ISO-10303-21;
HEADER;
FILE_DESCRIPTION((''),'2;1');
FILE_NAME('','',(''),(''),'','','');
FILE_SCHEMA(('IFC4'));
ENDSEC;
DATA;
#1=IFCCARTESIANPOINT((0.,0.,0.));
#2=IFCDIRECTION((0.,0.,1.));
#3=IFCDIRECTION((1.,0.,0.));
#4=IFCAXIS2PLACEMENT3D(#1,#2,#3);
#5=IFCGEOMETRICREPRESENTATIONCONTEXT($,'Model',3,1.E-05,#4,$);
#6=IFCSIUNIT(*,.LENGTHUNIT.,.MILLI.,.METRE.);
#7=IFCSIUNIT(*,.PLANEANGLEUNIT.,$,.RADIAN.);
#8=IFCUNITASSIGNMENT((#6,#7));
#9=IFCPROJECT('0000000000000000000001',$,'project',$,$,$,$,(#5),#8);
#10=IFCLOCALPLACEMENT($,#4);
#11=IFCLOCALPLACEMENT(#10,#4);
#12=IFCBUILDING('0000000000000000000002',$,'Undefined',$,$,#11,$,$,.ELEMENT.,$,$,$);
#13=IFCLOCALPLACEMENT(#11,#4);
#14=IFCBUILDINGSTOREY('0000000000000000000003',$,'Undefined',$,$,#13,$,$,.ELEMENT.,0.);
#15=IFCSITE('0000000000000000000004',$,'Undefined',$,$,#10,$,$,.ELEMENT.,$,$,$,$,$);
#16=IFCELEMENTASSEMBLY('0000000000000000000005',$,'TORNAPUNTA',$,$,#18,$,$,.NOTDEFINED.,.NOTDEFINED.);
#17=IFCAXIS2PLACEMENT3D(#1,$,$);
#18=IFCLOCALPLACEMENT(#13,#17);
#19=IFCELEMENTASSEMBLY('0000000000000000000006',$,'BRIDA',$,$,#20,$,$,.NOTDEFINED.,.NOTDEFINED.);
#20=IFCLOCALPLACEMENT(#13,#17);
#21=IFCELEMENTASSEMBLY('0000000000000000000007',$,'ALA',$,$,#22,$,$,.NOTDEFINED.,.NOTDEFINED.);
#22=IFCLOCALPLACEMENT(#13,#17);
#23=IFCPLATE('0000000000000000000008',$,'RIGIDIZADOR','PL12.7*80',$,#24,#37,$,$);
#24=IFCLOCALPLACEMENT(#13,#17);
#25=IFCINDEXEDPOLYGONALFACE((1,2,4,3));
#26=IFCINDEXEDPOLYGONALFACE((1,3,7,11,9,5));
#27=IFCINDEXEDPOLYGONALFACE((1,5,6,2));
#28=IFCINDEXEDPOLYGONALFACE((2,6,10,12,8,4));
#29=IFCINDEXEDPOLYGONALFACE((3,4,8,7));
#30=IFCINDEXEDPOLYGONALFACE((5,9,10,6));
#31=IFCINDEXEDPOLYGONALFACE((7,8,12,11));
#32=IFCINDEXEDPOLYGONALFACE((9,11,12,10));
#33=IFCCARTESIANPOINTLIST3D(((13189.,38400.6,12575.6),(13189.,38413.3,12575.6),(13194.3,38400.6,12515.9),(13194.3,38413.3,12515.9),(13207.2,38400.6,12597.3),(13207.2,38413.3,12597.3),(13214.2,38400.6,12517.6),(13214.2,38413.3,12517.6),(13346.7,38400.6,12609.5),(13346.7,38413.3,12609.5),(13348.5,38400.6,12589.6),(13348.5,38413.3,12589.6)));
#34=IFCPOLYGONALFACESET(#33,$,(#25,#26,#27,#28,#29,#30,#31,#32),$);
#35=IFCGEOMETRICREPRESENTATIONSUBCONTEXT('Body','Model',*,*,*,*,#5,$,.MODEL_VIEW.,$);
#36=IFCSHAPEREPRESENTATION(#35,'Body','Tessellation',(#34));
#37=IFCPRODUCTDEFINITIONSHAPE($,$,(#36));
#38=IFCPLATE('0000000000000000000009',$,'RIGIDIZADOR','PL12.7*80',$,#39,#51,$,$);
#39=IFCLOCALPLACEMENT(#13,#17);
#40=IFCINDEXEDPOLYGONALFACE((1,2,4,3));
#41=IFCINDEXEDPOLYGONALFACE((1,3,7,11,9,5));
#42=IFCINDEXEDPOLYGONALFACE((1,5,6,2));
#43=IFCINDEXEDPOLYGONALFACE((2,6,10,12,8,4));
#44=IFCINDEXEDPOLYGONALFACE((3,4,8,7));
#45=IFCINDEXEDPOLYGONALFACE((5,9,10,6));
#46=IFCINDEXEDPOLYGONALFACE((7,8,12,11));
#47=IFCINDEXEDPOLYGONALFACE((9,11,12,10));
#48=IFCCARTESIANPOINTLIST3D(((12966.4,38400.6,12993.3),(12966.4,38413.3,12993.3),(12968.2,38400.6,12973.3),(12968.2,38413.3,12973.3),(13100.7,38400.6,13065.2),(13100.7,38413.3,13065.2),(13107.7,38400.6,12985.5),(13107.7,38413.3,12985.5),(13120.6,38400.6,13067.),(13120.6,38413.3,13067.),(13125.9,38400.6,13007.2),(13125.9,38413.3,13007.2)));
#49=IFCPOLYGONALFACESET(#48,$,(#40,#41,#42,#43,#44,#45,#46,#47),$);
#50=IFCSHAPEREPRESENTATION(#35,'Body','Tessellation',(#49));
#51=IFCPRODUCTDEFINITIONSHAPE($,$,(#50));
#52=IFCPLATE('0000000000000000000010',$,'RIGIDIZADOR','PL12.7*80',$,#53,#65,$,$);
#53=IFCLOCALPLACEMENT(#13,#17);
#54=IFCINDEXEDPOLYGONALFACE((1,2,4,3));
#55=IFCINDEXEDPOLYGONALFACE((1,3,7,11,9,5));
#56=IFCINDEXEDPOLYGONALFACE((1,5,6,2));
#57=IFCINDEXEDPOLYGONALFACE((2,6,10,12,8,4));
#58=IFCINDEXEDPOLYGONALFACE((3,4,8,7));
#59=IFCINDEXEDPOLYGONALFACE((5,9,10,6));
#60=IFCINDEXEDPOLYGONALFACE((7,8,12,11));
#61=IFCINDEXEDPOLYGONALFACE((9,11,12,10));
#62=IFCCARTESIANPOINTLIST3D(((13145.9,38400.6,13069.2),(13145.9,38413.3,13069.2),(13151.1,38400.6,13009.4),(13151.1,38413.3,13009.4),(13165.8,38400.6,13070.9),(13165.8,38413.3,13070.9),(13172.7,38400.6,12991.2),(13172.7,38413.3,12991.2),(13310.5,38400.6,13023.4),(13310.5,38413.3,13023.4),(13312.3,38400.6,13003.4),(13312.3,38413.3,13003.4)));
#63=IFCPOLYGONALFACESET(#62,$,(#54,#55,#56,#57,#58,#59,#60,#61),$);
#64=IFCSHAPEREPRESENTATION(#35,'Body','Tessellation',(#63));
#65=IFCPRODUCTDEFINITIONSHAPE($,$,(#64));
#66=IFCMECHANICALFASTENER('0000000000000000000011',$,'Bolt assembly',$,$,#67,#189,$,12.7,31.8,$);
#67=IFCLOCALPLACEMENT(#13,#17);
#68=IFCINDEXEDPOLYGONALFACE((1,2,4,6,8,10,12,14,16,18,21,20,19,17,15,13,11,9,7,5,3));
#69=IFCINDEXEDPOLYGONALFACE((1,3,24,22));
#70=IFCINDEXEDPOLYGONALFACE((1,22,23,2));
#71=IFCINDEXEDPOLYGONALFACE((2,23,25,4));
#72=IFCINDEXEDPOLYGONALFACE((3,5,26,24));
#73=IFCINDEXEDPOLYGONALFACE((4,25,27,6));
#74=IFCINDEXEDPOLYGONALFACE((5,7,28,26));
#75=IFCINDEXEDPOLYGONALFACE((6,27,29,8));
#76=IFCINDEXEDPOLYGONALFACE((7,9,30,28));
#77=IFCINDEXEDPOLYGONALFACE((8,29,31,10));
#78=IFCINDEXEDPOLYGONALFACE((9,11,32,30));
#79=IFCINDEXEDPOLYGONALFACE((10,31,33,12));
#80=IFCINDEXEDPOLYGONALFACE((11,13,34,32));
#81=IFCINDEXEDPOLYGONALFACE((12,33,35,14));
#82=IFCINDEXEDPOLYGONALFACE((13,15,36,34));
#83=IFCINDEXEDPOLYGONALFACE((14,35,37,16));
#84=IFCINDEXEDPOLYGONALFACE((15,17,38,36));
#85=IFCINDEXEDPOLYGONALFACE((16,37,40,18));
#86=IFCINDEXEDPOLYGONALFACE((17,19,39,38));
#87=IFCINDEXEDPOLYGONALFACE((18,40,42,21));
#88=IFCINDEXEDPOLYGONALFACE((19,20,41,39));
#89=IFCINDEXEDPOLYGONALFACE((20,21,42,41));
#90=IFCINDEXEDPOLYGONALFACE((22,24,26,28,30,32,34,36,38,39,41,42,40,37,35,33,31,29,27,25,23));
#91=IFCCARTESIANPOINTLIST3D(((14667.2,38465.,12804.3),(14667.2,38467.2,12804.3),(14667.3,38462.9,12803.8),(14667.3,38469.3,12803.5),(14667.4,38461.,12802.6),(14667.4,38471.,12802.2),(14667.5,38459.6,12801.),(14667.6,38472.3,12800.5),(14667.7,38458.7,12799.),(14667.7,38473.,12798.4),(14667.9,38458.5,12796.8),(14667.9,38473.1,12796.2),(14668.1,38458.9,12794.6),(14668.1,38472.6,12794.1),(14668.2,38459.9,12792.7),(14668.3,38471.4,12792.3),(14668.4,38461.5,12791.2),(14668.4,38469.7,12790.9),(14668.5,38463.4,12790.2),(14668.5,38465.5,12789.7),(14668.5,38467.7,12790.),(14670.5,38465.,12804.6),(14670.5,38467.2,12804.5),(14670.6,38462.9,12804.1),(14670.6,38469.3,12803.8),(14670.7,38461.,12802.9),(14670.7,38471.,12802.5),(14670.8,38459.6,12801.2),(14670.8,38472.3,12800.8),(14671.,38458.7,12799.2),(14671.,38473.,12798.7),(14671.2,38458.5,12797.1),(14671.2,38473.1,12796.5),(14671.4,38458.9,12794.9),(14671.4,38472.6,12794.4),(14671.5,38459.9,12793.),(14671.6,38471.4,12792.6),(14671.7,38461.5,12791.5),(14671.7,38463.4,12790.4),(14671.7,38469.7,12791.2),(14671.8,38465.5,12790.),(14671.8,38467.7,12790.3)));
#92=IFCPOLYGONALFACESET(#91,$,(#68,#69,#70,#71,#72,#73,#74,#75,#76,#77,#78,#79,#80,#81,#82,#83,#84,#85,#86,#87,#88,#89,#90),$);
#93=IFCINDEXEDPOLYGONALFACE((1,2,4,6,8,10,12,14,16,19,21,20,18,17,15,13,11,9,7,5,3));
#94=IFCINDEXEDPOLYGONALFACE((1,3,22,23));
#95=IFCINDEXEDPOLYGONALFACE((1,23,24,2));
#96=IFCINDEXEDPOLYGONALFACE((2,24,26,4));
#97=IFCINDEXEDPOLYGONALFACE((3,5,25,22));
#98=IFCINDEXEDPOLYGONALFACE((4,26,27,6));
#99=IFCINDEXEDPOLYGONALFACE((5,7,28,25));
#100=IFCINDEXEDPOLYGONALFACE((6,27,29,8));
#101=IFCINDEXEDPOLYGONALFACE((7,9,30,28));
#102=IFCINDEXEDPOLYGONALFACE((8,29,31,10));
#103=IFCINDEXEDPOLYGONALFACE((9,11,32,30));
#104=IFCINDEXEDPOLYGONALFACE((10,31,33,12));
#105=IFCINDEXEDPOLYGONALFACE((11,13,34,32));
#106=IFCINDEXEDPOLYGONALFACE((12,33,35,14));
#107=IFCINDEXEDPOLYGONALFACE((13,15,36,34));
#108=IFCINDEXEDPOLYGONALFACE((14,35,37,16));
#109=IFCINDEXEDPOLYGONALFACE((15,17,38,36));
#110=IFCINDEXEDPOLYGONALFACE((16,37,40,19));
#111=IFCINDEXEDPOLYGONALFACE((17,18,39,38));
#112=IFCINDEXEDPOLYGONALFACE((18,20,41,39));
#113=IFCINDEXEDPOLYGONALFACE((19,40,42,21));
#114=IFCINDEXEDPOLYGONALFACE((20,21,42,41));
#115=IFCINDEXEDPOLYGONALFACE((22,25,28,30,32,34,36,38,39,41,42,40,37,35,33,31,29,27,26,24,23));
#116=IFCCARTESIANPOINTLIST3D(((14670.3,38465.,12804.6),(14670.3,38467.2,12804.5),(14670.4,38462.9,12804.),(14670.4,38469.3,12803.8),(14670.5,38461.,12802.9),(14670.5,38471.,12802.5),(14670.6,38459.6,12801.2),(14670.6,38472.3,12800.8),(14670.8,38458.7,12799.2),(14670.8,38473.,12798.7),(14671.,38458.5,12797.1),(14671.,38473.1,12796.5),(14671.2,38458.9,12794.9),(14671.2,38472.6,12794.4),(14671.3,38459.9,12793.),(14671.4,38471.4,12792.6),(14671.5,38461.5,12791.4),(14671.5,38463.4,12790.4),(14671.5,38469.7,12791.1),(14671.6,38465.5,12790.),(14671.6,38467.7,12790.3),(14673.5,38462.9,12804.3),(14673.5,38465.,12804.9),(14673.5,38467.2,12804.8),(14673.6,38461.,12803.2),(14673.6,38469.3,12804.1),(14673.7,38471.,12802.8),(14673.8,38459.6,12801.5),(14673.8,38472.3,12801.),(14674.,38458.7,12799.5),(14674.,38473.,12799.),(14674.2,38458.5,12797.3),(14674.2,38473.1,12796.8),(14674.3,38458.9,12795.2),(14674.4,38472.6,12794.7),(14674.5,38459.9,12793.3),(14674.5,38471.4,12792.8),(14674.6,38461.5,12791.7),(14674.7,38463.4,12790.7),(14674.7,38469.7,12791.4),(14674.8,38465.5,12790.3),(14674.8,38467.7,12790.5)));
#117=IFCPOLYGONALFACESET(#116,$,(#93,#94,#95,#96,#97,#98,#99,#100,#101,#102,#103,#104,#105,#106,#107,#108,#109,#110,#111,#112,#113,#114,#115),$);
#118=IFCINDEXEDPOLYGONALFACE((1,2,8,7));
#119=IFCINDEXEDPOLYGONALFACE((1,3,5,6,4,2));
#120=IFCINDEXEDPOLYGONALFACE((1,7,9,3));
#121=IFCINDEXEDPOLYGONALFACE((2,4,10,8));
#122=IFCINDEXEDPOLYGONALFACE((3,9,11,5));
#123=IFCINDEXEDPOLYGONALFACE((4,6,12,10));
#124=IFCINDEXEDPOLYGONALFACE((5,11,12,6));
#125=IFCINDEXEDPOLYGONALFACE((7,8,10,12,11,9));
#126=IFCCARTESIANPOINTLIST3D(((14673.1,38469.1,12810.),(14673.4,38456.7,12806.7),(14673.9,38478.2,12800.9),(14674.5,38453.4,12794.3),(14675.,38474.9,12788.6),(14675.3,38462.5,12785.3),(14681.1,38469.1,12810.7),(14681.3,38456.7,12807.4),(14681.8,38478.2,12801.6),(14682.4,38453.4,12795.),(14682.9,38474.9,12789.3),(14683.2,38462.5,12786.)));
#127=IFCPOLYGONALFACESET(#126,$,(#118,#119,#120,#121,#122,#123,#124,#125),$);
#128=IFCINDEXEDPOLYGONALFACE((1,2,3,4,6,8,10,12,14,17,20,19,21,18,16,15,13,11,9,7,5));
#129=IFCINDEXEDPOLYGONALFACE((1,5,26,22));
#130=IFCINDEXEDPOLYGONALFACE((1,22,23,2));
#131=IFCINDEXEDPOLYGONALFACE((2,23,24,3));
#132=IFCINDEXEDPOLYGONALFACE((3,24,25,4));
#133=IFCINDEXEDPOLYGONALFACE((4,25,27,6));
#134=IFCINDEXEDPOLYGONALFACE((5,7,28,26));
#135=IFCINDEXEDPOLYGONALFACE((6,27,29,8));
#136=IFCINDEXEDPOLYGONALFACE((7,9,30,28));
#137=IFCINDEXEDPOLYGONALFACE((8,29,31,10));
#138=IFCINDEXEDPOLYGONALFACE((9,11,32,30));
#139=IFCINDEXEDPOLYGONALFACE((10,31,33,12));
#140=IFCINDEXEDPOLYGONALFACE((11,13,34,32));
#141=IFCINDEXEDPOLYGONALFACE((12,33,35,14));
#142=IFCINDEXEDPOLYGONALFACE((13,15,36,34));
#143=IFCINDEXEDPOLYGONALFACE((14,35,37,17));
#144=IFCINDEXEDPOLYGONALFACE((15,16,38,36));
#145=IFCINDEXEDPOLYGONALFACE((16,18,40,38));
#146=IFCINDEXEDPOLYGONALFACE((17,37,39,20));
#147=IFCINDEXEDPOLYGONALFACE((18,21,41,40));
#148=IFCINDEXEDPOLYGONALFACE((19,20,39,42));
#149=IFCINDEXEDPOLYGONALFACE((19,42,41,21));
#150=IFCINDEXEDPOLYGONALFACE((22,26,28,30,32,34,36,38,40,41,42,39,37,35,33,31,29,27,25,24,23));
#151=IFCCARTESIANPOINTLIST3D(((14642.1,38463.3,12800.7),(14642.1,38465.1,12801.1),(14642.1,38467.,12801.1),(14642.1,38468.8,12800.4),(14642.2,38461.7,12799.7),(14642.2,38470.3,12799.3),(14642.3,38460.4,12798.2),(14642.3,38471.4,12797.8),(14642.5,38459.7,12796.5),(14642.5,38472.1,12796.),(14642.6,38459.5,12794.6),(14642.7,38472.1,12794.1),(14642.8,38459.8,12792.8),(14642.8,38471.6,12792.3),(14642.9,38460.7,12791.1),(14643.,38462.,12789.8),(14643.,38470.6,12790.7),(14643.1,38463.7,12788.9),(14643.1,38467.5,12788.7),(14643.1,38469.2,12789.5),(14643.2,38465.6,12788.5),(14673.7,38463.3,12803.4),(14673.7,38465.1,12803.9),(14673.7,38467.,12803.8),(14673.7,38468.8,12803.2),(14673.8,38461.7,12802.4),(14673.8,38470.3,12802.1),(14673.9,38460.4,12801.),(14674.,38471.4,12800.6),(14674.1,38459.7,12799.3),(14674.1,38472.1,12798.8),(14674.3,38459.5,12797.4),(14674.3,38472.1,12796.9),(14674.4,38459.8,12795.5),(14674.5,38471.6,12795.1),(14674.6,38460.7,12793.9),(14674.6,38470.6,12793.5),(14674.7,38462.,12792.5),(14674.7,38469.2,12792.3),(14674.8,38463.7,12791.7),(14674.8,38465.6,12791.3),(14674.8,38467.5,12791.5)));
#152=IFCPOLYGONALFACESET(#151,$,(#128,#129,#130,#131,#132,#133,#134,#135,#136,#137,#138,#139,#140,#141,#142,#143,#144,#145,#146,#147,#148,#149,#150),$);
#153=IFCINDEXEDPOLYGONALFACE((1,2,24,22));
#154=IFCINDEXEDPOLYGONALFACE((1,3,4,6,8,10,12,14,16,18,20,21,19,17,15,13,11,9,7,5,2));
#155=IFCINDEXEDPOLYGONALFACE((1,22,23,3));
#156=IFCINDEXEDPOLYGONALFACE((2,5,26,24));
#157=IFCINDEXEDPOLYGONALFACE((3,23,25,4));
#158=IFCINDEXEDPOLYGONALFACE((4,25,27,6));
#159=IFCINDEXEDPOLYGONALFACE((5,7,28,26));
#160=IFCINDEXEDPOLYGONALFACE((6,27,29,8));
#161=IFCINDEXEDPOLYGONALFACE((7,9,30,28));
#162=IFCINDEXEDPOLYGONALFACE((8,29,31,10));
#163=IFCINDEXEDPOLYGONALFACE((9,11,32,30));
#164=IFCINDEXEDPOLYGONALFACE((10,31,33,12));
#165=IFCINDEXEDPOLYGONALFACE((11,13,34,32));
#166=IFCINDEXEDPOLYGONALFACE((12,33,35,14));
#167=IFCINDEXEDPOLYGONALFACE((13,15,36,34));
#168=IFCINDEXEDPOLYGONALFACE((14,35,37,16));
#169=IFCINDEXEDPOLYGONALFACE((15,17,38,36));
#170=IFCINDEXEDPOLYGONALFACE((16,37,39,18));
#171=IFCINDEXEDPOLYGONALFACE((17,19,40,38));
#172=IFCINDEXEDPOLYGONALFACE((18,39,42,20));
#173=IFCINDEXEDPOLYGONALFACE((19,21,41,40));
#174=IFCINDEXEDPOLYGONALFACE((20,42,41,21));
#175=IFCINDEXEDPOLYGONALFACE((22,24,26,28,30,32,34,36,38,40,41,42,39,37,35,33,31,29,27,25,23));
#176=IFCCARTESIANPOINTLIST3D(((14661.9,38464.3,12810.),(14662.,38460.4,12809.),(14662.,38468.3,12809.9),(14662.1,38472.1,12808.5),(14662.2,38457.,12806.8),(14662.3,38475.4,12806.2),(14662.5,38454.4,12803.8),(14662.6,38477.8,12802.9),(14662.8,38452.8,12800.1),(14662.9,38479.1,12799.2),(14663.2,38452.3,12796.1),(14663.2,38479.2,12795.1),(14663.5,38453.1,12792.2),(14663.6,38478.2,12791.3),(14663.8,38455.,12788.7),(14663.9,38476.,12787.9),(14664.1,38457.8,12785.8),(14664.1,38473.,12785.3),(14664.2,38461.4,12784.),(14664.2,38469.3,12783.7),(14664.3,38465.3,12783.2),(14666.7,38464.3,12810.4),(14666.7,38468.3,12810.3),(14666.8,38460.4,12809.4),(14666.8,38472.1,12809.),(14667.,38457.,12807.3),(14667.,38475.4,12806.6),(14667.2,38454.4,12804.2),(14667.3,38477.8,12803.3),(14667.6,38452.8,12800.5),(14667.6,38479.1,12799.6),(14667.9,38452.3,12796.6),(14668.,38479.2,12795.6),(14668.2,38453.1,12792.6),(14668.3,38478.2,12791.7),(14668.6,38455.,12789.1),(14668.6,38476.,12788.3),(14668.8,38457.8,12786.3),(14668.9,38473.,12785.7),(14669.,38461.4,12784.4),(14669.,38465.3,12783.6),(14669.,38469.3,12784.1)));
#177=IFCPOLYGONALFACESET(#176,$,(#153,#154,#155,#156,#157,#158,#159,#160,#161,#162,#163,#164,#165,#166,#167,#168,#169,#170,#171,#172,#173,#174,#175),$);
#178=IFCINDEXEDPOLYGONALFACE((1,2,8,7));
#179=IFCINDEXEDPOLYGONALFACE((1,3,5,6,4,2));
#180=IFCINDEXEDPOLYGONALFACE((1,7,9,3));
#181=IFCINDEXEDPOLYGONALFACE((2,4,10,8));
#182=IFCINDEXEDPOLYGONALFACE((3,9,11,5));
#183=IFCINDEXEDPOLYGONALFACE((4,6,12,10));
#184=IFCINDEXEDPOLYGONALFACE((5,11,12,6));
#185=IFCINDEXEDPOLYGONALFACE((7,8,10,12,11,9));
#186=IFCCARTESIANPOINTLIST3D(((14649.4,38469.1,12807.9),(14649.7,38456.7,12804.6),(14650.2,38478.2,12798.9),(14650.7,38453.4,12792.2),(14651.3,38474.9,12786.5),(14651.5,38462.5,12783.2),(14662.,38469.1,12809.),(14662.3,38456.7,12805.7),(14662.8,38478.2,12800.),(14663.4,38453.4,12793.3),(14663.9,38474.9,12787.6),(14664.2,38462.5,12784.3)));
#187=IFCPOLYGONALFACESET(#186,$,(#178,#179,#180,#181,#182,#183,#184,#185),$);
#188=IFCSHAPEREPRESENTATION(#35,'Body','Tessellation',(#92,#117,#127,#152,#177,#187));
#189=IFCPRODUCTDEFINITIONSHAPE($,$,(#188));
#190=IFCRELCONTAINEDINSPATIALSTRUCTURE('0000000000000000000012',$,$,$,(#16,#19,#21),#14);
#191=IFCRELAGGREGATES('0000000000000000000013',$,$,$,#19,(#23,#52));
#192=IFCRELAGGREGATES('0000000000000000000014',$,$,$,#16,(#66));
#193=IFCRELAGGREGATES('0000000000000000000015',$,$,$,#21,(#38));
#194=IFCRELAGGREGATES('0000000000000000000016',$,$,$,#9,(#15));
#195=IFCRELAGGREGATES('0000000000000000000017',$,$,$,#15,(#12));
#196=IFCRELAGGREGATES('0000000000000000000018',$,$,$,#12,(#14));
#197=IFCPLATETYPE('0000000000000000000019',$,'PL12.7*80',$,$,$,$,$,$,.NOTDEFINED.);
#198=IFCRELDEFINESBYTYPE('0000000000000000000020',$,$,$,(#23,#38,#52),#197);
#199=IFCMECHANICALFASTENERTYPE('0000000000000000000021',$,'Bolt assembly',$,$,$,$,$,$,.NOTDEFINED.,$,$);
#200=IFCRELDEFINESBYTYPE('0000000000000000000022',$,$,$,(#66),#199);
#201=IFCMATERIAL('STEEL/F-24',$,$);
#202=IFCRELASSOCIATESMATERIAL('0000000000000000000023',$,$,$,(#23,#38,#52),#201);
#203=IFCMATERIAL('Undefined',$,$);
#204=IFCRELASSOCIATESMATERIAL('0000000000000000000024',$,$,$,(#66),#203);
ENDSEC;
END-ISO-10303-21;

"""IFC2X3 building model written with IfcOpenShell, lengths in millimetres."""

from ifc_helpers import new_model, si_unit, frame, origin_with_axes, origin_2d_with_axis, place, context, subcontext, project, spatial, polyline, circle, outline, extrude, source, transform, mapped, material, type_object, element, aggregate, save


model = new_model("IFC2X3")

# Units and contexts
model_context = context("Model", 3, precision=1e-05, world=origin_with_axes())
body_context = subcontext(model_context, "Body", "Model", "MODEL_VIEW")
ifc_project = project(units=[si_unit("LENGTHUNIT", "METRE", prefix="MILLI"), si_unit("PLANEANGLEUNIT", "RADIAN")], contexts=[model_context])

# Site, building, storey
site_placement = place(None, origin_with_axes())
site = spatial("IfcSite", under=ifc_project, at=site_placement, Name="Undefined", CompositionType="ELEMENT")
building_placement = place(site_placement, origin_with_axes())
building = spatial("IfcBuilding", under=site, at=building_placement, Name="Undefined", CompositionType="ELEMENT")
storey_placement = place(building_placement, origin_with_axes())
storey = spatial("IfcBuildingStorey", under=building, at=storey_placement, Name="Undefined", CompositionType="ELEMENT", Elevation=0.0)

# Element assembly
assembly_1_placement = place(storey_placement, origin_with_axes())
assembly_1 = element("IfcElementAssembly", 1, at=assembly_1_placement, inside=storey, Name="TORNAPUNTA", AssemblyPlace="NOTDEFINED", PredefinedType="NOTDEFINED")
ifc_material_1 = material(Name="STEEL/F-24")

# Element assembly
assembly_2_placement = place(storey_placement, origin_with_axes())
assembly_2 = element("IfcElementAssembly", 2, at=assembly_2_placement, inside=storey, Name="BRIDA", AssemblyPlace="NOTDEFINED", PredefinedType="NOTDEFINED")

# Element assembly
assembly_3_placement = place(storey_placement, origin_with_axes())
assembly_3 = element("IfcElementAssembly", 3, at=assembly_3_placement, inside=storey, Name="ALA", AssemblyPlace="NOTDEFINED", PredefinedType="NOTDEFINED")

# Plates
plate_type_1 = type_object("IfcPlateType", Name="PL12.7*80", PredefinedType="NOTDEFINED")
plate_1_placement = place(assembly_2_placement, frame((13187.3, 38407.0, 12595.6), z_axis=(0.0, -1.0, 0.0), x_axis=(0.087972, 0.0, -0.996123)))
plate_1 = element("IfcPlate", 4, at=plate_1_placement, type_object=plate_type_1, material=ifc_material_1, Name="RIGIDIZADOR", Description="PL12.7*80", context=body_context, shape_type="SweptSolid", body=[
    extrude(outline(polyline([(0.0, 20.0), (20.0, 0.0), (80.0, 0.0), (80.0, 20.0), (20.1, 160.0), (0.1, 160.1), (0.0, 20.0)])), frame((0.0, 0.0, -6.3), z_axis=(0.0, 0.0, 1.0), x_axis=(1.0, 0.0, 0.0)), (0.0, 0.0, 1.0), 12.7),
])
plate_2_placement = place(assembly_3_placement, frame((13127.6, 38407.0, 12987.3), z_axis=(0.0, -1.0, 0.0), x_axis=(-0.087972, 0.0, 0.996123)))
plate_2 = element("IfcPlate", 5, at=plate_2_placement, type_object=plate_type_1, material=ifc_material_1, Name="RIGIDIZADOR", Description="PL12.7*80", context=body_context, shape_type="SweptSolid", body=[
    extrude(outline(polyline([(0.0, 20.0), (20.0, 0.0), (80.0, 0.0), (80.0, 20.0), (20.1, 160.0), (0.1, 160.1), (0.0, 20.0)])), frame((0.0, 0.0, -6.3), z_axis=(0.0, 0.0, 1.0), x_axis=(1.0, 0.0, 0.0)), (0.0, 0.0, 1.0), 12.7),
])
plate_3_placement = place(assembly_2_placement, frame((13152.8, 38407.0, 12989.5), z_axis=(0.0, 1.0, 0.0), x_axis=(-0.086338, 0.0, 0.996266)))
plate_3 = element("IfcPlate", 6, at=plate_3_placement, type_object=plate_type_1, material=ifc_material_1, Name="RIGIDIZADOR", Description="PL12.7*80", context=body_context, shape_type="SweptSolid", body=[
    extrude(outline(polyline([(0.0, 20.0), (20.0, 0.0), (80.0, 0.0), (80.0, 20.0), (20.1, 160.0), (0.1, 160.1), (0.0, 20.0)])), frame((0.0, 0.0, -6.3), z_axis=(0.0, 0.0, 1.0), x_axis=(1.0, 0.0, 0.0)), (0.0, 0.0, 1.0), 12.7),
])
aggregate(assembly_2, [plate_1, plate_3])

# Mechanical fastener
ifc_material_2 = material(Name="Undefined")
mechanical_fastener_type = type_object("IfcMechanicalFastenerType", Name="Bolt assembly")
shared_shape_1 = source(origin_with_axes(), body_context, "Body", "SweptSolid", [
    extrude(circle(Radius=7.3, at=origin_2d_with_axis()), frame((0.0, -0.1, 0.0), z_axis=(0.0, 1.0, 0.0), x_axis=(1.0, 0.0, 0.0)), (0.0, 0.0, 1.0), 3.3),
    extrude(circle(Radius=7.3, at=origin_2d_with_axis()), frame((0.0, -3.1, 0.0), z_axis=(0.0, 1.0, 0.0), x_axis=(1.0, 0.0, 0.0)), (0.0, 0.0, 1.0), 3.2),
    extrude(outline(polyline([(11.1, -6.4), (11.1, 6.4), (0.0, 12.8), (-11.1, 6.4), (-11.1, -6.4), (0.0, -12.8), (11.1, -6.4)])), frame((0.0, -11.1, 0.0), z_axis=(0.0, 1.0, 0.0), x_axis=(1.0, 0.0, 0.0)), (0.0, 0.0, 1.0), 7.9),
    extrude(circle(Radius=6.3, at=origin_2d_with_axis()), frame((0.0, -3.2, 0.0), z_axis=(0.0, 1.0, 0.0), x_axis=(1.0, 0.0, 0.0)), (0.0, 0.0, 1.0), 31.8),
    extrude(circle(Radius=13.5, at=origin_2d_with_axis()), frame((0.0, 3.2, 0.0), z_axis=(0.0, 1.0, 0.0), x_axis=(1.0, 0.0, 0.0)), (0.0, 0.0, 1.0), 4.8),
    extrude(outline(polyline([(11.1, -6.4), (11.1, 6.4), (0.0, 12.8), (-11.1, 6.4), (-11.1, -6.4), (0.0, -12.8), (11.1, -6.4)])), frame((0.0, 8.0, 0.0), z_axis=(0.0, 1.0, 0.0), x_axis=(1.0, 0.0, 0.0)), (0.0, 0.0, 1.0), 12.7),
])
mechanical_fastener_1_placement = place(assembly_1_placement, frame((14671.0, 38465.8, 12797.3), z_axis=(-0.061628, -0.707107, 0.704416), x_axis=(-0.061628, 0.707107, 0.704416)))
mechanical_fastener_1 = element("IfcMechanicalFastener", 7, at=mechanical_fastener_1_placement, type_object=mechanical_fastener_type, material=ifc_material_2, Name="Bolt assembly", NominalDiameter=12.7, NominalLength=31.8, context=body_context, shape_type="MappedRepresentation", body=[
    mapped(shared_shape_1, transform((0.0, 0.0, 0.0))),
])
aggregate(assembly_1, [mechanical_fastener_1])

aggregate(assembly_3, [plate_2])

save(model, "model.ifc")
